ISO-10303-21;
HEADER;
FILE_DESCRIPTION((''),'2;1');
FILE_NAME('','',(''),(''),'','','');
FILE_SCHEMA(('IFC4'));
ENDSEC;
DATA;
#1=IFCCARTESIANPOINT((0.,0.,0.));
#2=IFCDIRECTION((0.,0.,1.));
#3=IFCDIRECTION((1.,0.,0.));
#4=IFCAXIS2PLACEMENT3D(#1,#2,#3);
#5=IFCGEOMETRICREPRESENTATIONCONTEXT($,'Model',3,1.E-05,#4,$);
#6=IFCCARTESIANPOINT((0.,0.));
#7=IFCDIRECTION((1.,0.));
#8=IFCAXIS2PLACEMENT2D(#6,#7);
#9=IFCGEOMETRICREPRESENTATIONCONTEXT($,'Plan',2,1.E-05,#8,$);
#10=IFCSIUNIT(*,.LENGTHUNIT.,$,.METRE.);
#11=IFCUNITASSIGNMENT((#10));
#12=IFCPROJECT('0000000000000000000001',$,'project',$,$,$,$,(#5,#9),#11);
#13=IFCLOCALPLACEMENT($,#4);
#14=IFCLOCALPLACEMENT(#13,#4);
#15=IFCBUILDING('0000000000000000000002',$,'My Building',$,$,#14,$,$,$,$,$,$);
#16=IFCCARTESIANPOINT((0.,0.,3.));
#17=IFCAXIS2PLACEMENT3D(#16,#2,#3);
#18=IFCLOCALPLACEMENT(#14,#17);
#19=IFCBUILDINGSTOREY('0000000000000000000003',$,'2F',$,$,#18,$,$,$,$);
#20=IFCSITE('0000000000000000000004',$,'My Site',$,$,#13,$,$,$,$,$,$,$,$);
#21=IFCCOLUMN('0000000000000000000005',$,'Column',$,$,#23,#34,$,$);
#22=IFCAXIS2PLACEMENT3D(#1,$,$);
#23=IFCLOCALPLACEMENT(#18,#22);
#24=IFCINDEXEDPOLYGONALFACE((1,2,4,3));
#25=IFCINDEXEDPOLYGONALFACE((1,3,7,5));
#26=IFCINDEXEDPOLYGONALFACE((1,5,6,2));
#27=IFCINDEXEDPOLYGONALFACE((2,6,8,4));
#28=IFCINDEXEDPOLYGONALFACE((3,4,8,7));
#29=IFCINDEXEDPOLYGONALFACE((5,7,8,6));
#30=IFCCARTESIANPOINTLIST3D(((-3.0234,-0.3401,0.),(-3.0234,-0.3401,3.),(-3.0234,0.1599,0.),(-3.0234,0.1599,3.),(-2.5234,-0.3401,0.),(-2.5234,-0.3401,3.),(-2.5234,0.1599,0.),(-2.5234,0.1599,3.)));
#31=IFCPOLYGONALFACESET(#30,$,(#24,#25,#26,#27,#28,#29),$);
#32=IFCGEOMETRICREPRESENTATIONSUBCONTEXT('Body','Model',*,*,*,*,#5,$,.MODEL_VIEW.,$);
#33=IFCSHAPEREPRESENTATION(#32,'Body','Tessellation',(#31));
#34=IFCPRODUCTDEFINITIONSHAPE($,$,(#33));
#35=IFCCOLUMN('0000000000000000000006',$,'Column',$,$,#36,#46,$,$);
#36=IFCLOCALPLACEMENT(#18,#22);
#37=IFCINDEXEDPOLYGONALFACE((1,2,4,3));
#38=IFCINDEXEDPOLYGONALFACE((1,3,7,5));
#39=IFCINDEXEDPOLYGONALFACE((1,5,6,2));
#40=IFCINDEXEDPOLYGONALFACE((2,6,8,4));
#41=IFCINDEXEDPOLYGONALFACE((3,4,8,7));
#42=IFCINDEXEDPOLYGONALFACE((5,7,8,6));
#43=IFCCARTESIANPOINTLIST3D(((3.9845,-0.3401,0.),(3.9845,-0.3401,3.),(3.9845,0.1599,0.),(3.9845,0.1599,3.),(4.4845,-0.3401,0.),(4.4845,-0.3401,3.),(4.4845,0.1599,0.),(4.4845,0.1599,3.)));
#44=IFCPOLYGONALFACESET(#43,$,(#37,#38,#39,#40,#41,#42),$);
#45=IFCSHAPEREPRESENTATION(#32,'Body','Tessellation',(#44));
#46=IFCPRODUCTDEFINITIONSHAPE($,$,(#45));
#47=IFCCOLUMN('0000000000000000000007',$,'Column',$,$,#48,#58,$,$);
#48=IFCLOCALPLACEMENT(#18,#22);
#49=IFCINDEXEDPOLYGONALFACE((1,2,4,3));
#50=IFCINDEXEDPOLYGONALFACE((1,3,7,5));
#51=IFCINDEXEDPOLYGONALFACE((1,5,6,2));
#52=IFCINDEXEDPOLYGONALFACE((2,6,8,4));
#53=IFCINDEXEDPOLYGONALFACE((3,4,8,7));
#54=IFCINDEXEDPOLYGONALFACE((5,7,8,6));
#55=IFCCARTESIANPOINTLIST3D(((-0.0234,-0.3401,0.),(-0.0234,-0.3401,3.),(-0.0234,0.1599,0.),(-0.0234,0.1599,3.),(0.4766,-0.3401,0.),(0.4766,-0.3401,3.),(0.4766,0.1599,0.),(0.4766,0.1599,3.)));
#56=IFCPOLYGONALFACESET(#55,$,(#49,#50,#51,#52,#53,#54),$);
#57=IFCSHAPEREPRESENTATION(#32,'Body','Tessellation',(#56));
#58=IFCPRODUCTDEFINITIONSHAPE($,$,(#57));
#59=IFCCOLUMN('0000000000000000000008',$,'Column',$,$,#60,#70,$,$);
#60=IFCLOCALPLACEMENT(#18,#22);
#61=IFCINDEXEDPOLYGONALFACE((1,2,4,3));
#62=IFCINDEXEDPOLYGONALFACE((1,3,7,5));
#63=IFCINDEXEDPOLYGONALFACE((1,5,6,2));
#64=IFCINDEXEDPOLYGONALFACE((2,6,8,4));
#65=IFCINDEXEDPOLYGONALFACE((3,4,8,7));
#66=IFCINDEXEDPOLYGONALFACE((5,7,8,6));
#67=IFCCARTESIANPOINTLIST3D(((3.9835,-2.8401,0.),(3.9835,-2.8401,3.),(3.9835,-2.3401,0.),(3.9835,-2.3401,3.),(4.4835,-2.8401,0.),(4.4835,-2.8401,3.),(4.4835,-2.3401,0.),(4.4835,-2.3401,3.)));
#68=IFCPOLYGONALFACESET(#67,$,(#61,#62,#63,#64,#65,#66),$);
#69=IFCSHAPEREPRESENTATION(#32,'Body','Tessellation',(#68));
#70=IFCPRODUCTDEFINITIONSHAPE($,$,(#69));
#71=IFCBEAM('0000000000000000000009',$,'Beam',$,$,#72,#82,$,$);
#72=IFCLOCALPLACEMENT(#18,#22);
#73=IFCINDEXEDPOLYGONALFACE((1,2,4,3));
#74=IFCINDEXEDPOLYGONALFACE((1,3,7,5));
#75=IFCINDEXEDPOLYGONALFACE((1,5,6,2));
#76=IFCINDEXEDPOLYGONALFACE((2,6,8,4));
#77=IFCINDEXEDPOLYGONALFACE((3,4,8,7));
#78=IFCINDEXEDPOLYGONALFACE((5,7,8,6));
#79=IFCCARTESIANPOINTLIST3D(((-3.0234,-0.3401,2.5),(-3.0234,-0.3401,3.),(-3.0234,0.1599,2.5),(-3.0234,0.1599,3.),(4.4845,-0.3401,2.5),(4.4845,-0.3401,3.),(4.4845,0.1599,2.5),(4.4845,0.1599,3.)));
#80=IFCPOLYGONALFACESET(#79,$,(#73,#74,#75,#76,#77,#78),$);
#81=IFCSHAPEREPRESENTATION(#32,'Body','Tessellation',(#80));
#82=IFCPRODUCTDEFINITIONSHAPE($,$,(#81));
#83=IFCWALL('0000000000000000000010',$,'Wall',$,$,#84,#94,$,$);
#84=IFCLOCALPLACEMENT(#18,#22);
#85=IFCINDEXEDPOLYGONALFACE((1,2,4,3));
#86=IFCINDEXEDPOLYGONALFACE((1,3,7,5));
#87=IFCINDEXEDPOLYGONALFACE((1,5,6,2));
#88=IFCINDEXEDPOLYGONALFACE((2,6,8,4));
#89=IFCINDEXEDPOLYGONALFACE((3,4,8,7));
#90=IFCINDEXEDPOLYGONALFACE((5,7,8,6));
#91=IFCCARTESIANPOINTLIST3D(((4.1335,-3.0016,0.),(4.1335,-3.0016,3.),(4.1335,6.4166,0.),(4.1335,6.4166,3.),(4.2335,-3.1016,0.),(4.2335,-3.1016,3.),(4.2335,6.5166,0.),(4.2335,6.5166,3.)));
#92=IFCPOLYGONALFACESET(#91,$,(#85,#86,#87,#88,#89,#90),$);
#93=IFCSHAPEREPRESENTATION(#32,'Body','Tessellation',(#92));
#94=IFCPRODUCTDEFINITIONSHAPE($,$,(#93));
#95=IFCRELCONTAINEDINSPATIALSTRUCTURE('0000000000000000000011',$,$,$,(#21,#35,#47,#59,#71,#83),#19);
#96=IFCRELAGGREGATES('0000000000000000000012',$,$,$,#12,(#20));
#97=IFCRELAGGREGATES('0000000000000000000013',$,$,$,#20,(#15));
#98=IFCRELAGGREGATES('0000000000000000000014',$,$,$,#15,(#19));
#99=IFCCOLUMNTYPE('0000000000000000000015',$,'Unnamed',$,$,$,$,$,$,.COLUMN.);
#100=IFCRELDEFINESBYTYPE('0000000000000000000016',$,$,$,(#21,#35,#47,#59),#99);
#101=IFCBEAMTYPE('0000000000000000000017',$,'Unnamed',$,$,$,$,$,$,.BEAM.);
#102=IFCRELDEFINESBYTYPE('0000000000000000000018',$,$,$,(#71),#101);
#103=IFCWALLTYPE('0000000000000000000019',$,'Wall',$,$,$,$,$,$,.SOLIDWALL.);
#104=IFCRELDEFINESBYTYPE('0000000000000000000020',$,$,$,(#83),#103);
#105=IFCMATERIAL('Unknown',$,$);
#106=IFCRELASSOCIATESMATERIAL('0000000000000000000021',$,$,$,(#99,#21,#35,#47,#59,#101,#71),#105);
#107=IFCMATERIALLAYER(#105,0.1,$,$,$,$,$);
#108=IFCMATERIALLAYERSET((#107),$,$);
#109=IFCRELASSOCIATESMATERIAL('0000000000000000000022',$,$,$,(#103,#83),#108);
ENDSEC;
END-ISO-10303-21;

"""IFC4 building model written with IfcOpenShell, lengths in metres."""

from ifc_helpers import new_model, si_unit, frame, origin_with_axes, origin_2d_with_axis, place, context, subcontext, project, spatial, line, indexed_curve, rectangle, outline, extrude, material, layer, layer_set, layer_usage, material_profile, profile_set, profile_usage, type_object, element, save


model = new_model("IFC4")

# Units and contexts
model_context = context("Model", 3, precision=1e-05, world=origin_with_axes())
plan_context = context("Plan", 2, precision=1e-05, world=origin_2d_with_axis())
body_context_1 = subcontext(model_context, "Body", "Model", "MODEL_VIEW")
ifc_project = project(units=[si_unit("LENGTHUNIT", "METRE")], contexts=[model_context, plan_context])

# Site, building, storey
site_placement = place(None, origin_with_axes())
site = spatial("IfcSite", under=ifc_project, at=site_placement, Name="My Site")
building_placement = place(site_placement, origin_with_axes())
building = spatial("IfcBuilding", under=site, at=building_placement, Name="My Building")
storey_placement = place(building_placement, frame((0.0, 0.0, 3.0), z_axis=(0.0, 0.0, 1.0), x_axis=(1.0, 0.0, 0.0)))
storey = spatial("IfcBuildingStorey", under=building, at=storey_placement, Name="2F")

# Columns
ifc_material = material(Name="Unknown")
ifc_material_profile_1 = material_profile(ifc_material, rectangle(XDim=0.5, YDim=0.5))
ifc_profile_set_1 = profile_set([ifc_material_profile_1])
ifc_profile_usage_1 = profile_usage(ifc_profile_set_1, cardinal=5)
column_type = type_object("IfcColumnType", Name="Unnamed", PredefinedType="COLUMN", material=ifc_profile_set_1)
column_1_placement = place(storey_placement, frame((-2.7734, -0.0901, 0.0), z_axis=(0.0, 0.0, 1.0), x_axis=(1.0, 0.0, 0.0)))
element("IfcColumn", 1, at=column_1_placement, inside=storey, type_object=column_type, material=ifc_profile_usage_1, Name="Column", context=body_context_1, shape_type="SweptSolid", body=[
    extrude(rectangle(XDim=0.5, YDim=0.5), origin_with_axes(), (0.0, 0.0, 1.0), 3.0),
])
ifc_profile_usage_2 = profile_usage(ifc_profile_set_1, cardinal=5)
column_2_placement = place(storey_placement, frame((4.2345, -0.0901, 0.0), z_axis=(0.0, 0.0, 1.0), x_axis=(1.0, 0.0, 0.0)))
element("IfcColumn", 2, at=column_2_placement, inside=storey, type_object=column_type, material=ifc_profile_usage_2, Name="Column", context=body_context_1, shape_type="SweptSolid", body=[
    extrude(rectangle(XDim=0.5, YDim=0.5), origin_with_axes(), (0.0, 0.0, 1.0), 3.0),
])
ifc_profile_usage_3 = profile_usage(ifc_profile_set_1, cardinal=5)
column_3_placement = place(storey_placement, frame((0.2266, -0.0901, 0.0), z_axis=(0.0, 0.0, 1.0), x_axis=(1.0, 0.0, 0.0)))
element("IfcColumn", 3, at=column_3_placement, inside=storey, type_object=column_type, material=ifc_profile_usage_3, Name="Column", context=body_context_1, shape_type="SweptSolid", body=[
    extrude(rectangle(XDim=0.5, YDim=0.5), origin_with_axes(), (0.0, 0.0, 1.0), 3.0),
])
ifc_profile_usage_4 = profile_usage(ifc_profile_set_1, cardinal=5)
column_4_placement = place(storey_placement, frame((4.2335, -2.5901, 0.0), z_axis=(0.0, 0.0, 1.0), x_axis=(1.0, 0.0, 0.0)))
element("IfcColumn", 4, at=column_4_placement, inside=storey, type_object=column_type, material=ifc_profile_usage_4, Name="Column", context=body_context_1, shape_type="SweptSolid", body=[
    extrude(rectangle(XDim=0.5, YDim=0.5), origin_with_axes(), (0.0, 0.0, 1.0), 3.0),
])

# Beam
ifc_material_profile_2 = material_profile(ifc_material, rectangle(XDim=0.5, YDim=0.5))
ifc_profile_set_2 = profile_set([ifc_material_profile_2])
ifc_profile_usage_5 = profile_usage(ifc_profile_set_2, cardinal=7)
beam_type = type_object("IfcBeamType", Name="Unnamed", PredefinedType="BEAM", material=ifc_profile_set_2)
beam_placement = place(storey_placement, frame((-3.0234, 0.1599, 3.0), z_axis=(1.0, 0.0, 0.0), x_axis=(0.0, 1.0, 0.0)))
element("IfcBeam", 5, at=beam_placement, inside=storey, type_object=beam_type, material=ifc_profile_usage_5, Name="Beam", context=body_context_1, shape_type="SweptSolid", body=[
    extrude(rectangle(XDim=0.5, YDim=0.5), frame((-0.25, -0.25, 0.0), z_axis=(0.0, 0.0, 1.0), x_axis=(1.0, 0.0, 0.0)), (0.0, 0.0, 1.0), 7.5078),
])

# Wall
ifc_layer_1 = layer(ifc_material, 0.1)
ifc_layer_set_1 = layer_set([ifc_layer_1])
ifc_layer_usage_1 = layer_usage(ifc_layer_set_1, "AXIS2", "POSITIVE", 0.0)
wall_type = type_object("IfcWallType", Name="Wall", PredefinedType="SOLIDWALL", material=ifc_layer_set_1)
wall_1_placement = place(storey_placement, frame((4.2335, -3.1016, 0.0), z_axis=(0.0, 0.0, 1.0), x_axis=(0.0, 1.0, 0.0)))
element("IfcWall", 6, at=wall_1_placement, inside=storey, type_object=wall_type, material=ifc_layer_usage_1, Name="Wall", context=body_context_1, shape_type="SweptSolid", body=[
    extrude(outline(indexed_curve([(0.0, 0.0), (0.1, 0.1), (9.5182, 0.1), (9.6182, 0.0)], segments=[line(1, 2, 3, 4, 1)])), origin_with_axes(), (0.0, 0.0, 1.0), 3.0),
])

save(model, "model.ifc")
